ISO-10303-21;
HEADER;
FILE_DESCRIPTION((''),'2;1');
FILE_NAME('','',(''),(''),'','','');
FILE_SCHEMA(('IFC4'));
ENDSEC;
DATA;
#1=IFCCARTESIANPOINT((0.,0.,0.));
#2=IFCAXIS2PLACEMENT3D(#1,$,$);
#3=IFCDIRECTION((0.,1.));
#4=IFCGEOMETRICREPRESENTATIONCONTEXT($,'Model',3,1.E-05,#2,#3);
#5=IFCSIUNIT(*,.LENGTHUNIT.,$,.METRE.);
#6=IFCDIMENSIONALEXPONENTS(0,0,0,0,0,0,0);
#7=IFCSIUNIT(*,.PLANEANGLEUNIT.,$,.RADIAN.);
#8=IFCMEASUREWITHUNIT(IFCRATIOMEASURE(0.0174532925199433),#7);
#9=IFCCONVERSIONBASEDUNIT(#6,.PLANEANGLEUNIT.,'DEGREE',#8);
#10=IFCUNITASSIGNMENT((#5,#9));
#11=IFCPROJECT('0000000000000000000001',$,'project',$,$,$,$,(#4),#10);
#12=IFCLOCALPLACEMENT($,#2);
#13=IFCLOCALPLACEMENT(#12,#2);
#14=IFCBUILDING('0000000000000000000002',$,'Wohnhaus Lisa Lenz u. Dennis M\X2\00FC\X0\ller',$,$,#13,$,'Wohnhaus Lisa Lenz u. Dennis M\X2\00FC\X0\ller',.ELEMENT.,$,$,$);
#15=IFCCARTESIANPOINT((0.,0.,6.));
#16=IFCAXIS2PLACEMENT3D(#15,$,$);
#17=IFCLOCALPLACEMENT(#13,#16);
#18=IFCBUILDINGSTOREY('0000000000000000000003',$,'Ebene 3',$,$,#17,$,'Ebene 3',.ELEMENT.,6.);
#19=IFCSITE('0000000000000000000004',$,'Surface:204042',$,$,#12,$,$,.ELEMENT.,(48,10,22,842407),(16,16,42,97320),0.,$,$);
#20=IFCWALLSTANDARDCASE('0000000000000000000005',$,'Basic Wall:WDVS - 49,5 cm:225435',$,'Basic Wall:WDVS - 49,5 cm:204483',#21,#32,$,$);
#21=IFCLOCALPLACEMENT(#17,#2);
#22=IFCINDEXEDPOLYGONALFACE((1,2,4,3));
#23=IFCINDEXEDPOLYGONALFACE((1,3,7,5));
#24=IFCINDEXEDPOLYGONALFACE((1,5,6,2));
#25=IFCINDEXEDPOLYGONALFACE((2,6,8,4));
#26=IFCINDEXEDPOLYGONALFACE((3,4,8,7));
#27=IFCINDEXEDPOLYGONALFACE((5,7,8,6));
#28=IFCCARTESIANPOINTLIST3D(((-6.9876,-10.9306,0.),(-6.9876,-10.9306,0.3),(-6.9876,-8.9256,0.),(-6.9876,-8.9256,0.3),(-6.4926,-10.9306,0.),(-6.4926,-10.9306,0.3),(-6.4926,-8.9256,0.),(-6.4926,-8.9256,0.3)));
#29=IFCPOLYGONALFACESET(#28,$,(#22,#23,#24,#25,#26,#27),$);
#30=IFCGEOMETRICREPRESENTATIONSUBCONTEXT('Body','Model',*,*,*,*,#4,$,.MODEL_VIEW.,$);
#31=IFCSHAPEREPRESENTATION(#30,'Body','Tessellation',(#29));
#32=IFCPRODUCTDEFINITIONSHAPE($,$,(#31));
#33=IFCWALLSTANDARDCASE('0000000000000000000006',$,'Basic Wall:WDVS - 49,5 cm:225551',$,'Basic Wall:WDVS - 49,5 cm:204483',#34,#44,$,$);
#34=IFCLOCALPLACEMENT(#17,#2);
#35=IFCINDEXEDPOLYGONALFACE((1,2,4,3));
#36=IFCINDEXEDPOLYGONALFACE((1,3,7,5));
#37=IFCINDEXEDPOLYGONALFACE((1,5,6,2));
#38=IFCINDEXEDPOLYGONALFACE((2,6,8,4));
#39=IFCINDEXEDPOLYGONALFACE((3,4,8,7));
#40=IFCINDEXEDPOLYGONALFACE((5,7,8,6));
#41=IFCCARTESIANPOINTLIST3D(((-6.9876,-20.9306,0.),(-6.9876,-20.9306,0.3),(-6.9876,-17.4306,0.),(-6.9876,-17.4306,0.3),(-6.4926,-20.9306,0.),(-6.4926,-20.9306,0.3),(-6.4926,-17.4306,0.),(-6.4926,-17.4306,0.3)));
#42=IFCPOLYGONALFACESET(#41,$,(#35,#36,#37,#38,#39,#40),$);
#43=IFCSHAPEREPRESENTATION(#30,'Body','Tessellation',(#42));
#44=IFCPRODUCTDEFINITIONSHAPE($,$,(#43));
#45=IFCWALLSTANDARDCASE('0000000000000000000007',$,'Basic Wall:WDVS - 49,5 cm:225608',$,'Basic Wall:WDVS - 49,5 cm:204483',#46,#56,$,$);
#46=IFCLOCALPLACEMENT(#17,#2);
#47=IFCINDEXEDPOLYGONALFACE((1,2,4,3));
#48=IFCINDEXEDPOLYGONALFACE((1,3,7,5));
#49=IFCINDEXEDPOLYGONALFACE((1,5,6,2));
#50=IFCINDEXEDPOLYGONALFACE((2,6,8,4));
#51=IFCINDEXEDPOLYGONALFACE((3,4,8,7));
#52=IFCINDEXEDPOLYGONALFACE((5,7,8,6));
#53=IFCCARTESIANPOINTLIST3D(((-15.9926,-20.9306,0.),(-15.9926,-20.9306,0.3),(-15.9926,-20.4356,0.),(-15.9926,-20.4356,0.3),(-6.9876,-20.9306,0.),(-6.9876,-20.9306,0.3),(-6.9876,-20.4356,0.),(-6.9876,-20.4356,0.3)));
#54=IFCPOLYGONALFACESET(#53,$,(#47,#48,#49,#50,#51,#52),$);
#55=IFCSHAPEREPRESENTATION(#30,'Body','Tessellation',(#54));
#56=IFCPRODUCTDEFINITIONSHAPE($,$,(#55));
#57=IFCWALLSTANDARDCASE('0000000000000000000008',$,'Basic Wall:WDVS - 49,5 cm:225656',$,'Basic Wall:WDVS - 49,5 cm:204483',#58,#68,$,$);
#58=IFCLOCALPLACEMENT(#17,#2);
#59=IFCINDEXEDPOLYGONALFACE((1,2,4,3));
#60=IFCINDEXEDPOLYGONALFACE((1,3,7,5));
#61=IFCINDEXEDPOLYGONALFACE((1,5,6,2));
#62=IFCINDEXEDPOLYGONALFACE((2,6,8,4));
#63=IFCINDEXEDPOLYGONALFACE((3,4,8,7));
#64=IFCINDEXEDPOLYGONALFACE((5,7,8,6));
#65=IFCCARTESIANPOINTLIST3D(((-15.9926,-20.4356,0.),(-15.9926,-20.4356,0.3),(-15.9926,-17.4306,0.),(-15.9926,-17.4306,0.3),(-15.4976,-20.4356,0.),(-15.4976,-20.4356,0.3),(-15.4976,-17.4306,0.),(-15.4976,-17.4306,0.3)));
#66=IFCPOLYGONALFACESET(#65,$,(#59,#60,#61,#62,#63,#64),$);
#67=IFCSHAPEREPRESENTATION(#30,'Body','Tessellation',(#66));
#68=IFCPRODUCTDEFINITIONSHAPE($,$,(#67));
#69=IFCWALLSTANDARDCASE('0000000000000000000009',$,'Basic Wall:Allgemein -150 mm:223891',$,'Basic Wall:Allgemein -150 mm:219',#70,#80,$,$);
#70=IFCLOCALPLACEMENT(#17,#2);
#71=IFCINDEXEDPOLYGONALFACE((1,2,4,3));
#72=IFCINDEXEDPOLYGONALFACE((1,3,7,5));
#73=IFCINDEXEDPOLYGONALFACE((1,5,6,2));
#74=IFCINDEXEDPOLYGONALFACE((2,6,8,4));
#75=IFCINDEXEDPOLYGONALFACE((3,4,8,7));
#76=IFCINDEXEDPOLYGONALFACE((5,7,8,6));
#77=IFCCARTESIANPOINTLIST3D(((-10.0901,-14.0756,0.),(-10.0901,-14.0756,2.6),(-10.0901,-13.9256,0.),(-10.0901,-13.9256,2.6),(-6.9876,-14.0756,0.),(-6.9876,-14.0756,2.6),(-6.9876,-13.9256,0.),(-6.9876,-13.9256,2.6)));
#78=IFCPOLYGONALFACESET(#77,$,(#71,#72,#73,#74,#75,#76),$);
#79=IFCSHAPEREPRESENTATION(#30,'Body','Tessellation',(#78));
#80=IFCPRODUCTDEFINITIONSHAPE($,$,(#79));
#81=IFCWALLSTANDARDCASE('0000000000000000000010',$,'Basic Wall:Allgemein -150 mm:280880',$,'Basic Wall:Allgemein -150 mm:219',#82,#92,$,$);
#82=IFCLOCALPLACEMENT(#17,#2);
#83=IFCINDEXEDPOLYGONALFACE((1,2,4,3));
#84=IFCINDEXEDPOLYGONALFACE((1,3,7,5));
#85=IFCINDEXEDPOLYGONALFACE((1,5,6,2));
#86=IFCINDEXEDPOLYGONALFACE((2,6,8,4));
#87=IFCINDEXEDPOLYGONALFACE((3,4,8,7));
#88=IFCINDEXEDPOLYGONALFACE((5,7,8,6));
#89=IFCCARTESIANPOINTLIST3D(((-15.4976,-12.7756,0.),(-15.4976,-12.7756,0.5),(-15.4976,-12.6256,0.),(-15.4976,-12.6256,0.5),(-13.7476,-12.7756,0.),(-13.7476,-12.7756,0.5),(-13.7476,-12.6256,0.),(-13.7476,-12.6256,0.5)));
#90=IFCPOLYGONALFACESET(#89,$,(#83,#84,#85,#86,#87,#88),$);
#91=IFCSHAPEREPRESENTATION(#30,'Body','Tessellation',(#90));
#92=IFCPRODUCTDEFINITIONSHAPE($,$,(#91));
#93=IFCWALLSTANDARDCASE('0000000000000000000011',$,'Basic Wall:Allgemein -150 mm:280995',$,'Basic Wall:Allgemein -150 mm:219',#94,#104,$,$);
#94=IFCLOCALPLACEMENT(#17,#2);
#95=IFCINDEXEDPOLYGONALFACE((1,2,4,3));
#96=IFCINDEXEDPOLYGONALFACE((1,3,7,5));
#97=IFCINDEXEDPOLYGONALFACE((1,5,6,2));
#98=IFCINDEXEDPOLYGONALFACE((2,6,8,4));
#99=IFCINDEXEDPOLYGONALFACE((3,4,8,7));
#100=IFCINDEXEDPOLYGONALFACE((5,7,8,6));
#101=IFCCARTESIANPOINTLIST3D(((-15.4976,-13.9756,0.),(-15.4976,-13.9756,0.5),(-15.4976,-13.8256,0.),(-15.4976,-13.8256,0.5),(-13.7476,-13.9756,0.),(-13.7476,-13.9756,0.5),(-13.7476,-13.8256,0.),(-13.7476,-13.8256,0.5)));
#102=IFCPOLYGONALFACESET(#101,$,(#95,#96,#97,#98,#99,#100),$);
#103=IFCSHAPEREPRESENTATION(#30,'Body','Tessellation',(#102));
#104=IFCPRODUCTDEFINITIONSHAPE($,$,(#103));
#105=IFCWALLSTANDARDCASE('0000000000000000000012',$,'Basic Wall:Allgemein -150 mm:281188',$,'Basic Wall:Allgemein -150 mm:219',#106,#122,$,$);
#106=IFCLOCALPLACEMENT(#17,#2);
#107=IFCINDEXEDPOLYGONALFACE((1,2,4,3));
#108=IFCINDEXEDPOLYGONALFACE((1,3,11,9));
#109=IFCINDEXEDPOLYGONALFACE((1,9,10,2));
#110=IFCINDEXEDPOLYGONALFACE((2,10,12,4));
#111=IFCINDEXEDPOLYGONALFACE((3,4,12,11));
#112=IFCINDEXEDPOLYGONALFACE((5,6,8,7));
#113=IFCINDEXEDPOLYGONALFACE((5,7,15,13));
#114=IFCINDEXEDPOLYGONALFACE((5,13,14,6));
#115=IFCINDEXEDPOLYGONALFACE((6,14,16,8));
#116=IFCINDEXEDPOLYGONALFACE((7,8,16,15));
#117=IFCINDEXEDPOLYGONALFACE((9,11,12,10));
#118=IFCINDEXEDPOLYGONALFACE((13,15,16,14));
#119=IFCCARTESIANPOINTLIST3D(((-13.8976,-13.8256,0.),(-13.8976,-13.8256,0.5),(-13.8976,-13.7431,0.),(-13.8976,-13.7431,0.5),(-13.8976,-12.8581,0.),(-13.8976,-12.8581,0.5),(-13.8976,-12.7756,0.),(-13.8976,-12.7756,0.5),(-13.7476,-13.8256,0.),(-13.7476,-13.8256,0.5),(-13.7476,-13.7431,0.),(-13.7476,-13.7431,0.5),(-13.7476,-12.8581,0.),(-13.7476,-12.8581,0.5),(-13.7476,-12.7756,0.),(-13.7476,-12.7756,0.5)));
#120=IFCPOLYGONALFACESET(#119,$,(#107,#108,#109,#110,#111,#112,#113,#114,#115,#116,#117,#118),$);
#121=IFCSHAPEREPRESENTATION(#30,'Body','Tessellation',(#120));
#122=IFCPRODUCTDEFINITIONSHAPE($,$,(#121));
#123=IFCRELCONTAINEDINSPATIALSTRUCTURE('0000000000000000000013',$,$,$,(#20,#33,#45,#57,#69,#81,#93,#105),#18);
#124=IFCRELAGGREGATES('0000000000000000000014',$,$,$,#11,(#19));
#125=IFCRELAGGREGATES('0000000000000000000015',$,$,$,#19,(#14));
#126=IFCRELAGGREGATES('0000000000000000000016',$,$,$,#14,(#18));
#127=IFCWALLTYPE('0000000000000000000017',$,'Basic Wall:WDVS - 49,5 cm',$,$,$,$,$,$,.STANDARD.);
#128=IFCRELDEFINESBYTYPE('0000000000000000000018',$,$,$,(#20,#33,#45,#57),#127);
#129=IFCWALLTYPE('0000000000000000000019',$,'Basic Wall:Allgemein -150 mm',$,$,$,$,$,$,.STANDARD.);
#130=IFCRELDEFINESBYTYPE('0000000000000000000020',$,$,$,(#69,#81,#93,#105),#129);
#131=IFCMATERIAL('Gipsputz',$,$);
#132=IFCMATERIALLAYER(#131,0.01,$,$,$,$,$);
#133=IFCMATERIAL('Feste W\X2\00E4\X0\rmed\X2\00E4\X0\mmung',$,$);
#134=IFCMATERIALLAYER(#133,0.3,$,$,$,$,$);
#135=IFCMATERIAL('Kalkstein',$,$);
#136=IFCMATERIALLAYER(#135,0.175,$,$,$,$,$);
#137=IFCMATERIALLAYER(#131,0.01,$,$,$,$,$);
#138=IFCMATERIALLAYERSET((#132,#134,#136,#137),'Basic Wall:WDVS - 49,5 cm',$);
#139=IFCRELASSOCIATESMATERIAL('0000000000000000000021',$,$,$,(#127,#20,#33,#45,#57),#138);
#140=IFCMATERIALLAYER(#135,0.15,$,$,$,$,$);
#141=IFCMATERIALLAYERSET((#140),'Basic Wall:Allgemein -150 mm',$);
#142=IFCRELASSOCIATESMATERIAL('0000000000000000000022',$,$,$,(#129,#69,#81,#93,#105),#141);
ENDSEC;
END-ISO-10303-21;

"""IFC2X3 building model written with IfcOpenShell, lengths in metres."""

from ifc_helpers import new_model, entity, si_unit, converted_unit, direction, frame, frame_2d, origin, place, context, subcontext, project, spatial, polyline, rectangle, extrude, clip, bounded_halfspace, material, layer, layer_set, layer_usage, type_object, element, save


model = new_model("IFC2X3")

# Units and contexts
model_context = context("Model", 3, precision=1e-05, world=origin(), true_north=direction((0.0, 1.0)))
body_context = subcontext(model_context, "Body", "Model", "MODEL_VIEW")
ifc_project = project(units=[si_unit("LENGTHUNIT", "METRE"), converted_unit("PLANEANGLEUNIT", "DEGREE", entity("IfcRatioMeasure", 0.0174532925199433), si_unit("PLANEANGLEUNIT", "RADIAN"), dimensions=[0, 0, 0, 0, 0, 0, 0])], contexts=[model_context])

# Site, building, storey
site_placement = place(None, origin())
site = spatial("IfcSite", under=ifc_project, at=site_placement, Name="Surface:204042", CompositionType="ELEMENT", RefLatitude=(48, 10, 22, 842407), RefLongitude=(16, 16, 42, 97320), RefElevation=0.0)
building_placement = place(site_placement, origin())
building = spatial("IfcBuilding", under=site, at=building_placement, Name="Wohnhaus Lisa Lenz u. Dennis Müller", LongName="Wohnhaus Lisa Lenz u. Dennis Müller", CompositionType="ELEMENT")
storey_placement = place(building_placement, frame((0.0, 0.0, 6.0)))
storey = spatial("IfcBuildingStorey", under=building, at=storey_placement, Name="Ebene 3", LongName="Ebene 3", CompositionType="ELEMENT", Elevation=6.0)

# Shared definitions
ifc_material_1 = material(Name="Gipsputz")
ifc_layer_1 = layer(ifc_material_1, 0.01)
ifc_material_2 = material(Name="Feste Wärmedämmung")
ifc_layer_2 = layer(ifc_material_2, 0.3)
ifc_material_3 = material(Name="Kalkstein")
ifc_layer_3 = layer(ifc_material_3, 0.175)
ifc_layer_4 = layer(ifc_material_1, 0.01)
ifc_layer_set_1 = layer_set([ifc_layer_1, ifc_layer_2, ifc_layer_3, ifc_layer_4], Name="Basic Wall:WDVS - 49,5 cm")
wall_type_1 = type_object("IfcWallType", Name="Basic Wall:WDVS - 49,5 cm", PredefinedType="STANDARD", material=ifc_layer_set_1)

# Walls
ifc_layer_usage_1 = layer_usage(ifc_layer_set_1, "AXIS2", "NEGATIVE", 0.2475)
wall_1_placement = place(storey_placement, frame((-6.7401, -8.9256, 0.0), z_axis=(0.0, 0.0, 1.0), x_axis=(0.0, -1.0, 0.0)))
element("IfcWallStandardCase", 1, at=wall_1_placement, inside=storey, type_object=wall_type_1, material=ifc_layer_usage_1, Name="Basic Wall:WDVS - 49,5 cm:225435", ObjectType="Basic Wall:WDVS - 49,5 cm:204483", context=body_context, shape_type="SweptSolid", body=[
    extrude(rectangle(XDim=2.005, YDim=0.495, at=frame_2d((1.0025, 0.0), x_axis=(-1.0, 0.0))), origin(), (0.0, 0.0, 1.0), 0.3),
])
ifc_layer_usage_2 = layer_usage(ifc_layer_set_1, "AXIS2", "NEGATIVE", 0.2475)
wall_2_placement = place(storey_placement, frame((-6.7401, -17.4306, 0.0), z_axis=(0.0, 0.0, 1.0), x_axis=(0.0, -1.0, 0.0)))
element("IfcWallStandardCase", 2, at=wall_2_placement, inside=storey, type_object=wall_type_1, material=ifc_layer_usage_2, Name="Basic Wall:WDVS - 49,5 cm:225551", ObjectType="Basic Wall:WDVS - 49,5 cm:204483", context=body_context, shape_type="SweptSolid", body=[
    extrude(rectangle(XDim=3.5, YDim=0.495, at=frame_2d((1.75, 0.0), x_axis=(-1.0, 0.0))), origin(), (0.0, 0.0, 1.0), 0.3),
])
ifc_layer_usage_3 = layer_usage(ifc_layer_set_1, "AXIS2", "NEGATIVE", 0.2475)
wall_3_placement = place(storey_placement, frame((-6.9876, -20.6831, 0.0), z_axis=(0.0, 0.0, 1.0), x_axis=(-1.0, 0.0, 0.0)))
element("IfcWallStandardCase", 3, at=wall_3_placement, inside=storey, type_object=wall_type_1, material=ifc_layer_usage_3, Name="Basic Wall:WDVS - 49,5 cm:225608", ObjectType="Basic Wall:WDVS - 49,5 cm:204483", context=body_context, shape_type="SweptSolid", body=[
    extrude(rectangle(XDim=9.005, YDim=0.495, at=frame_2d((4.5025, 0.0), x_axis=(-1.0, 0.0))), origin(), (0.0, 0.0, 1.0), 0.3),
])
ifc_layer_usage_4 = layer_usage(ifc_layer_set_1, "AXIS2", "NEGATIVE", 0.2475)
wall_4_placement = place(storey_placement, frame((-15.7451, -20.4356, 0.0), z_axis=(0.0, 0.0, 1.0), x_axis=(0.0, 1.0, 0.0)))
element("IfcWallStandardCase", 4, at=wall_4_placement, inside=storey, type_object=wall_type_1, material=ifc_layer_usage_4, Name="Basic Wall:WDVS - 49,5 cm:225656", ObjectType="Basic Wall:WDVS - 49,5 cm:204483", context=body_context, shape_type="SweptSolid", body=[
    extrude(rectangle(XDim=3.005, YDim=0.495, at=frame_2d((1.5025, 0.0), x_axis=(-1.0, 0.0))), origin(), (0.0, 0.0, 1.0), 0.3),
])
ifc_layer_5 = layer(ifc_material_3, 0.15)
ifc_layer_set_2 = layer_set([ifc_layer_5], Name="Basic Wall:Allgemein -150 mm")
ifc_layer_usage_5 = layer_usage(ifc_layer_set_2, "AXIS2", "NEGATIVE", 0.075)
wall_type_2 = type_object("IfcWallType", Name="Basic Wall:Allgemein -150 mm", PredefinedType="STANDARD", material=ifc_layer_set_2)
wall_5_placement = place(storey_placement, frame((-6.9876, -14.0006, 0.0), z_axis=(0.0, 0.0, 1.0), x_axis=(-1.0, 0.0, 0.0)))
element("IfcWallStandardCase", 5, at=wall_5_placement, inside=storey, type_object=wall_type_2, material=ifc_layer_usage_5, Name="Basic Wall:Allgemein -150 mm:223891", ObjectType="Basic Wall:Allgemein -150 mm:219", context=body_context, shape_type="Clipping", body=[
    clip(extrude(rectangle(XDim=3.1025, YDim=0.15, at=frame_2d((1.5513, 0.0), x_axis=(-1.0, 0.0))), origin(), (0.0, 0.0, 1.0), 2.6), bounded_halfspace(frame((0.0, -0.075, 2.6), z_axis=(0.0, 0.0, -1.0), x_axis=(0.0, 1.0, 0.0)), True, frame((0.0, -0.075, 2.6)), polyline([(0.0, 0.0), (3.1025, 0.0), (3.1025, 0.15), (0.0, 0.15), (0.0, 0.0)]))),
])
ifc_layer_usage_6 = layer_usage(ifc_layer_set_2, "AXIS2", "NEGATIVE", 0.075)
wall_6_placement = place(storey_placement, frame((-15.4976, -12.7006, 0.0)))
element("IfcWallStandardCase", 6, at=wall_6_placement, inside=storey, type_object=wall_type_2, material=ifc_layer_usage_6, Name="Basic Wall:Allgemein -150 mm:280880", ObjectType="Basic Wall:Allgemein -150 mm:219", context=body_context, shape_type="SweptSolid", body=[
    extrude(rectangle(XDim=1.75, YDim=0.15, at=frame_2d((0.875, 0.0), x_axis=(-1.0, 0.0))), origin(), (0.0, 0.0, 1.0), 0.5),
])
ifc_layer_usage_7 = layer_usage(ifc_layer_set_2, "AXIS2", "NEGATIVE", 0.075)
wall_7_placement = place(storey_placement, frame((-15.4976, -13.9006, 0.0)))
element("IfcWallStandardCase", 7, at=wall_7_placement, inside=storey, type_object=wall_type_2, material=ifc_layer_usage_7, Name="Basic Wall:Allgemein -150 mm:280995", ObjectType="Basic Wall:Allgemein -150 mm:219", context=body_context, shape_type="SweptSolid", body=[
    extrude(rectangle(XDim=1.75, YDim=0.15, at=frame_2d((0.875, 0.0), x_axis=(-1.0, 0.0))), origin(), (0.0, 0.0, 1.0), 0.5),
])

# Wall, opening
ifc_layer_usage_8 = layer_usage(ifc_layer_set_2, "AXIS2", "NEGATIVE", 0.075)
wall_8_placement = place(storey_placement, frame((-13.8226, -12.7756, 0.0), z_axis=(0.0, 0.0, 1.0), x_axis=(0.0, -1.0, 0.0)))
wall_8 = element("IfcWallStandardCase", 8, at=wall_8_placement, inside=storey, type_object=wall_type_2, material=ifc_layer_usage_8, Name="Basic Wall:Allgemein -150 mm:281188", ObjectType="Basic Wall:Allgemein -150 mm:219", context=body_context, shape_type="SweptSolid", body=[
    extrude(rectangle(XDim=1.05, YDim=0.15, at=frame_2d((0.525, 0.0), x_axis=(-1.0, 0.0))), origin(), (0.0, 0.0, 1.0), 0.5),
])
opening_1_placement = place(wall_8_placement, frame((0.9675, 0.075, 0.0)))
element("IfcOpeningElement", 9, at=opening_1_placement, cuts=wall_8, ObjectType="Opening", context=body_context, shape_type="SweptSolid", body=[
    extrude(rectangle(XDim=2.235, YDim=0.885, at=frame_2d((1.1175, 0.4425), x_axis=(1.0, 0.0))), frame((0.0, 0.0, 0.0), z_axis=(0.0, -1.0, 0.0), x_axis=(0.0, 0.0, 1.0)), (0.0, 0.0, 1.0), 0.15),
])

save(model, "model.ifc")
